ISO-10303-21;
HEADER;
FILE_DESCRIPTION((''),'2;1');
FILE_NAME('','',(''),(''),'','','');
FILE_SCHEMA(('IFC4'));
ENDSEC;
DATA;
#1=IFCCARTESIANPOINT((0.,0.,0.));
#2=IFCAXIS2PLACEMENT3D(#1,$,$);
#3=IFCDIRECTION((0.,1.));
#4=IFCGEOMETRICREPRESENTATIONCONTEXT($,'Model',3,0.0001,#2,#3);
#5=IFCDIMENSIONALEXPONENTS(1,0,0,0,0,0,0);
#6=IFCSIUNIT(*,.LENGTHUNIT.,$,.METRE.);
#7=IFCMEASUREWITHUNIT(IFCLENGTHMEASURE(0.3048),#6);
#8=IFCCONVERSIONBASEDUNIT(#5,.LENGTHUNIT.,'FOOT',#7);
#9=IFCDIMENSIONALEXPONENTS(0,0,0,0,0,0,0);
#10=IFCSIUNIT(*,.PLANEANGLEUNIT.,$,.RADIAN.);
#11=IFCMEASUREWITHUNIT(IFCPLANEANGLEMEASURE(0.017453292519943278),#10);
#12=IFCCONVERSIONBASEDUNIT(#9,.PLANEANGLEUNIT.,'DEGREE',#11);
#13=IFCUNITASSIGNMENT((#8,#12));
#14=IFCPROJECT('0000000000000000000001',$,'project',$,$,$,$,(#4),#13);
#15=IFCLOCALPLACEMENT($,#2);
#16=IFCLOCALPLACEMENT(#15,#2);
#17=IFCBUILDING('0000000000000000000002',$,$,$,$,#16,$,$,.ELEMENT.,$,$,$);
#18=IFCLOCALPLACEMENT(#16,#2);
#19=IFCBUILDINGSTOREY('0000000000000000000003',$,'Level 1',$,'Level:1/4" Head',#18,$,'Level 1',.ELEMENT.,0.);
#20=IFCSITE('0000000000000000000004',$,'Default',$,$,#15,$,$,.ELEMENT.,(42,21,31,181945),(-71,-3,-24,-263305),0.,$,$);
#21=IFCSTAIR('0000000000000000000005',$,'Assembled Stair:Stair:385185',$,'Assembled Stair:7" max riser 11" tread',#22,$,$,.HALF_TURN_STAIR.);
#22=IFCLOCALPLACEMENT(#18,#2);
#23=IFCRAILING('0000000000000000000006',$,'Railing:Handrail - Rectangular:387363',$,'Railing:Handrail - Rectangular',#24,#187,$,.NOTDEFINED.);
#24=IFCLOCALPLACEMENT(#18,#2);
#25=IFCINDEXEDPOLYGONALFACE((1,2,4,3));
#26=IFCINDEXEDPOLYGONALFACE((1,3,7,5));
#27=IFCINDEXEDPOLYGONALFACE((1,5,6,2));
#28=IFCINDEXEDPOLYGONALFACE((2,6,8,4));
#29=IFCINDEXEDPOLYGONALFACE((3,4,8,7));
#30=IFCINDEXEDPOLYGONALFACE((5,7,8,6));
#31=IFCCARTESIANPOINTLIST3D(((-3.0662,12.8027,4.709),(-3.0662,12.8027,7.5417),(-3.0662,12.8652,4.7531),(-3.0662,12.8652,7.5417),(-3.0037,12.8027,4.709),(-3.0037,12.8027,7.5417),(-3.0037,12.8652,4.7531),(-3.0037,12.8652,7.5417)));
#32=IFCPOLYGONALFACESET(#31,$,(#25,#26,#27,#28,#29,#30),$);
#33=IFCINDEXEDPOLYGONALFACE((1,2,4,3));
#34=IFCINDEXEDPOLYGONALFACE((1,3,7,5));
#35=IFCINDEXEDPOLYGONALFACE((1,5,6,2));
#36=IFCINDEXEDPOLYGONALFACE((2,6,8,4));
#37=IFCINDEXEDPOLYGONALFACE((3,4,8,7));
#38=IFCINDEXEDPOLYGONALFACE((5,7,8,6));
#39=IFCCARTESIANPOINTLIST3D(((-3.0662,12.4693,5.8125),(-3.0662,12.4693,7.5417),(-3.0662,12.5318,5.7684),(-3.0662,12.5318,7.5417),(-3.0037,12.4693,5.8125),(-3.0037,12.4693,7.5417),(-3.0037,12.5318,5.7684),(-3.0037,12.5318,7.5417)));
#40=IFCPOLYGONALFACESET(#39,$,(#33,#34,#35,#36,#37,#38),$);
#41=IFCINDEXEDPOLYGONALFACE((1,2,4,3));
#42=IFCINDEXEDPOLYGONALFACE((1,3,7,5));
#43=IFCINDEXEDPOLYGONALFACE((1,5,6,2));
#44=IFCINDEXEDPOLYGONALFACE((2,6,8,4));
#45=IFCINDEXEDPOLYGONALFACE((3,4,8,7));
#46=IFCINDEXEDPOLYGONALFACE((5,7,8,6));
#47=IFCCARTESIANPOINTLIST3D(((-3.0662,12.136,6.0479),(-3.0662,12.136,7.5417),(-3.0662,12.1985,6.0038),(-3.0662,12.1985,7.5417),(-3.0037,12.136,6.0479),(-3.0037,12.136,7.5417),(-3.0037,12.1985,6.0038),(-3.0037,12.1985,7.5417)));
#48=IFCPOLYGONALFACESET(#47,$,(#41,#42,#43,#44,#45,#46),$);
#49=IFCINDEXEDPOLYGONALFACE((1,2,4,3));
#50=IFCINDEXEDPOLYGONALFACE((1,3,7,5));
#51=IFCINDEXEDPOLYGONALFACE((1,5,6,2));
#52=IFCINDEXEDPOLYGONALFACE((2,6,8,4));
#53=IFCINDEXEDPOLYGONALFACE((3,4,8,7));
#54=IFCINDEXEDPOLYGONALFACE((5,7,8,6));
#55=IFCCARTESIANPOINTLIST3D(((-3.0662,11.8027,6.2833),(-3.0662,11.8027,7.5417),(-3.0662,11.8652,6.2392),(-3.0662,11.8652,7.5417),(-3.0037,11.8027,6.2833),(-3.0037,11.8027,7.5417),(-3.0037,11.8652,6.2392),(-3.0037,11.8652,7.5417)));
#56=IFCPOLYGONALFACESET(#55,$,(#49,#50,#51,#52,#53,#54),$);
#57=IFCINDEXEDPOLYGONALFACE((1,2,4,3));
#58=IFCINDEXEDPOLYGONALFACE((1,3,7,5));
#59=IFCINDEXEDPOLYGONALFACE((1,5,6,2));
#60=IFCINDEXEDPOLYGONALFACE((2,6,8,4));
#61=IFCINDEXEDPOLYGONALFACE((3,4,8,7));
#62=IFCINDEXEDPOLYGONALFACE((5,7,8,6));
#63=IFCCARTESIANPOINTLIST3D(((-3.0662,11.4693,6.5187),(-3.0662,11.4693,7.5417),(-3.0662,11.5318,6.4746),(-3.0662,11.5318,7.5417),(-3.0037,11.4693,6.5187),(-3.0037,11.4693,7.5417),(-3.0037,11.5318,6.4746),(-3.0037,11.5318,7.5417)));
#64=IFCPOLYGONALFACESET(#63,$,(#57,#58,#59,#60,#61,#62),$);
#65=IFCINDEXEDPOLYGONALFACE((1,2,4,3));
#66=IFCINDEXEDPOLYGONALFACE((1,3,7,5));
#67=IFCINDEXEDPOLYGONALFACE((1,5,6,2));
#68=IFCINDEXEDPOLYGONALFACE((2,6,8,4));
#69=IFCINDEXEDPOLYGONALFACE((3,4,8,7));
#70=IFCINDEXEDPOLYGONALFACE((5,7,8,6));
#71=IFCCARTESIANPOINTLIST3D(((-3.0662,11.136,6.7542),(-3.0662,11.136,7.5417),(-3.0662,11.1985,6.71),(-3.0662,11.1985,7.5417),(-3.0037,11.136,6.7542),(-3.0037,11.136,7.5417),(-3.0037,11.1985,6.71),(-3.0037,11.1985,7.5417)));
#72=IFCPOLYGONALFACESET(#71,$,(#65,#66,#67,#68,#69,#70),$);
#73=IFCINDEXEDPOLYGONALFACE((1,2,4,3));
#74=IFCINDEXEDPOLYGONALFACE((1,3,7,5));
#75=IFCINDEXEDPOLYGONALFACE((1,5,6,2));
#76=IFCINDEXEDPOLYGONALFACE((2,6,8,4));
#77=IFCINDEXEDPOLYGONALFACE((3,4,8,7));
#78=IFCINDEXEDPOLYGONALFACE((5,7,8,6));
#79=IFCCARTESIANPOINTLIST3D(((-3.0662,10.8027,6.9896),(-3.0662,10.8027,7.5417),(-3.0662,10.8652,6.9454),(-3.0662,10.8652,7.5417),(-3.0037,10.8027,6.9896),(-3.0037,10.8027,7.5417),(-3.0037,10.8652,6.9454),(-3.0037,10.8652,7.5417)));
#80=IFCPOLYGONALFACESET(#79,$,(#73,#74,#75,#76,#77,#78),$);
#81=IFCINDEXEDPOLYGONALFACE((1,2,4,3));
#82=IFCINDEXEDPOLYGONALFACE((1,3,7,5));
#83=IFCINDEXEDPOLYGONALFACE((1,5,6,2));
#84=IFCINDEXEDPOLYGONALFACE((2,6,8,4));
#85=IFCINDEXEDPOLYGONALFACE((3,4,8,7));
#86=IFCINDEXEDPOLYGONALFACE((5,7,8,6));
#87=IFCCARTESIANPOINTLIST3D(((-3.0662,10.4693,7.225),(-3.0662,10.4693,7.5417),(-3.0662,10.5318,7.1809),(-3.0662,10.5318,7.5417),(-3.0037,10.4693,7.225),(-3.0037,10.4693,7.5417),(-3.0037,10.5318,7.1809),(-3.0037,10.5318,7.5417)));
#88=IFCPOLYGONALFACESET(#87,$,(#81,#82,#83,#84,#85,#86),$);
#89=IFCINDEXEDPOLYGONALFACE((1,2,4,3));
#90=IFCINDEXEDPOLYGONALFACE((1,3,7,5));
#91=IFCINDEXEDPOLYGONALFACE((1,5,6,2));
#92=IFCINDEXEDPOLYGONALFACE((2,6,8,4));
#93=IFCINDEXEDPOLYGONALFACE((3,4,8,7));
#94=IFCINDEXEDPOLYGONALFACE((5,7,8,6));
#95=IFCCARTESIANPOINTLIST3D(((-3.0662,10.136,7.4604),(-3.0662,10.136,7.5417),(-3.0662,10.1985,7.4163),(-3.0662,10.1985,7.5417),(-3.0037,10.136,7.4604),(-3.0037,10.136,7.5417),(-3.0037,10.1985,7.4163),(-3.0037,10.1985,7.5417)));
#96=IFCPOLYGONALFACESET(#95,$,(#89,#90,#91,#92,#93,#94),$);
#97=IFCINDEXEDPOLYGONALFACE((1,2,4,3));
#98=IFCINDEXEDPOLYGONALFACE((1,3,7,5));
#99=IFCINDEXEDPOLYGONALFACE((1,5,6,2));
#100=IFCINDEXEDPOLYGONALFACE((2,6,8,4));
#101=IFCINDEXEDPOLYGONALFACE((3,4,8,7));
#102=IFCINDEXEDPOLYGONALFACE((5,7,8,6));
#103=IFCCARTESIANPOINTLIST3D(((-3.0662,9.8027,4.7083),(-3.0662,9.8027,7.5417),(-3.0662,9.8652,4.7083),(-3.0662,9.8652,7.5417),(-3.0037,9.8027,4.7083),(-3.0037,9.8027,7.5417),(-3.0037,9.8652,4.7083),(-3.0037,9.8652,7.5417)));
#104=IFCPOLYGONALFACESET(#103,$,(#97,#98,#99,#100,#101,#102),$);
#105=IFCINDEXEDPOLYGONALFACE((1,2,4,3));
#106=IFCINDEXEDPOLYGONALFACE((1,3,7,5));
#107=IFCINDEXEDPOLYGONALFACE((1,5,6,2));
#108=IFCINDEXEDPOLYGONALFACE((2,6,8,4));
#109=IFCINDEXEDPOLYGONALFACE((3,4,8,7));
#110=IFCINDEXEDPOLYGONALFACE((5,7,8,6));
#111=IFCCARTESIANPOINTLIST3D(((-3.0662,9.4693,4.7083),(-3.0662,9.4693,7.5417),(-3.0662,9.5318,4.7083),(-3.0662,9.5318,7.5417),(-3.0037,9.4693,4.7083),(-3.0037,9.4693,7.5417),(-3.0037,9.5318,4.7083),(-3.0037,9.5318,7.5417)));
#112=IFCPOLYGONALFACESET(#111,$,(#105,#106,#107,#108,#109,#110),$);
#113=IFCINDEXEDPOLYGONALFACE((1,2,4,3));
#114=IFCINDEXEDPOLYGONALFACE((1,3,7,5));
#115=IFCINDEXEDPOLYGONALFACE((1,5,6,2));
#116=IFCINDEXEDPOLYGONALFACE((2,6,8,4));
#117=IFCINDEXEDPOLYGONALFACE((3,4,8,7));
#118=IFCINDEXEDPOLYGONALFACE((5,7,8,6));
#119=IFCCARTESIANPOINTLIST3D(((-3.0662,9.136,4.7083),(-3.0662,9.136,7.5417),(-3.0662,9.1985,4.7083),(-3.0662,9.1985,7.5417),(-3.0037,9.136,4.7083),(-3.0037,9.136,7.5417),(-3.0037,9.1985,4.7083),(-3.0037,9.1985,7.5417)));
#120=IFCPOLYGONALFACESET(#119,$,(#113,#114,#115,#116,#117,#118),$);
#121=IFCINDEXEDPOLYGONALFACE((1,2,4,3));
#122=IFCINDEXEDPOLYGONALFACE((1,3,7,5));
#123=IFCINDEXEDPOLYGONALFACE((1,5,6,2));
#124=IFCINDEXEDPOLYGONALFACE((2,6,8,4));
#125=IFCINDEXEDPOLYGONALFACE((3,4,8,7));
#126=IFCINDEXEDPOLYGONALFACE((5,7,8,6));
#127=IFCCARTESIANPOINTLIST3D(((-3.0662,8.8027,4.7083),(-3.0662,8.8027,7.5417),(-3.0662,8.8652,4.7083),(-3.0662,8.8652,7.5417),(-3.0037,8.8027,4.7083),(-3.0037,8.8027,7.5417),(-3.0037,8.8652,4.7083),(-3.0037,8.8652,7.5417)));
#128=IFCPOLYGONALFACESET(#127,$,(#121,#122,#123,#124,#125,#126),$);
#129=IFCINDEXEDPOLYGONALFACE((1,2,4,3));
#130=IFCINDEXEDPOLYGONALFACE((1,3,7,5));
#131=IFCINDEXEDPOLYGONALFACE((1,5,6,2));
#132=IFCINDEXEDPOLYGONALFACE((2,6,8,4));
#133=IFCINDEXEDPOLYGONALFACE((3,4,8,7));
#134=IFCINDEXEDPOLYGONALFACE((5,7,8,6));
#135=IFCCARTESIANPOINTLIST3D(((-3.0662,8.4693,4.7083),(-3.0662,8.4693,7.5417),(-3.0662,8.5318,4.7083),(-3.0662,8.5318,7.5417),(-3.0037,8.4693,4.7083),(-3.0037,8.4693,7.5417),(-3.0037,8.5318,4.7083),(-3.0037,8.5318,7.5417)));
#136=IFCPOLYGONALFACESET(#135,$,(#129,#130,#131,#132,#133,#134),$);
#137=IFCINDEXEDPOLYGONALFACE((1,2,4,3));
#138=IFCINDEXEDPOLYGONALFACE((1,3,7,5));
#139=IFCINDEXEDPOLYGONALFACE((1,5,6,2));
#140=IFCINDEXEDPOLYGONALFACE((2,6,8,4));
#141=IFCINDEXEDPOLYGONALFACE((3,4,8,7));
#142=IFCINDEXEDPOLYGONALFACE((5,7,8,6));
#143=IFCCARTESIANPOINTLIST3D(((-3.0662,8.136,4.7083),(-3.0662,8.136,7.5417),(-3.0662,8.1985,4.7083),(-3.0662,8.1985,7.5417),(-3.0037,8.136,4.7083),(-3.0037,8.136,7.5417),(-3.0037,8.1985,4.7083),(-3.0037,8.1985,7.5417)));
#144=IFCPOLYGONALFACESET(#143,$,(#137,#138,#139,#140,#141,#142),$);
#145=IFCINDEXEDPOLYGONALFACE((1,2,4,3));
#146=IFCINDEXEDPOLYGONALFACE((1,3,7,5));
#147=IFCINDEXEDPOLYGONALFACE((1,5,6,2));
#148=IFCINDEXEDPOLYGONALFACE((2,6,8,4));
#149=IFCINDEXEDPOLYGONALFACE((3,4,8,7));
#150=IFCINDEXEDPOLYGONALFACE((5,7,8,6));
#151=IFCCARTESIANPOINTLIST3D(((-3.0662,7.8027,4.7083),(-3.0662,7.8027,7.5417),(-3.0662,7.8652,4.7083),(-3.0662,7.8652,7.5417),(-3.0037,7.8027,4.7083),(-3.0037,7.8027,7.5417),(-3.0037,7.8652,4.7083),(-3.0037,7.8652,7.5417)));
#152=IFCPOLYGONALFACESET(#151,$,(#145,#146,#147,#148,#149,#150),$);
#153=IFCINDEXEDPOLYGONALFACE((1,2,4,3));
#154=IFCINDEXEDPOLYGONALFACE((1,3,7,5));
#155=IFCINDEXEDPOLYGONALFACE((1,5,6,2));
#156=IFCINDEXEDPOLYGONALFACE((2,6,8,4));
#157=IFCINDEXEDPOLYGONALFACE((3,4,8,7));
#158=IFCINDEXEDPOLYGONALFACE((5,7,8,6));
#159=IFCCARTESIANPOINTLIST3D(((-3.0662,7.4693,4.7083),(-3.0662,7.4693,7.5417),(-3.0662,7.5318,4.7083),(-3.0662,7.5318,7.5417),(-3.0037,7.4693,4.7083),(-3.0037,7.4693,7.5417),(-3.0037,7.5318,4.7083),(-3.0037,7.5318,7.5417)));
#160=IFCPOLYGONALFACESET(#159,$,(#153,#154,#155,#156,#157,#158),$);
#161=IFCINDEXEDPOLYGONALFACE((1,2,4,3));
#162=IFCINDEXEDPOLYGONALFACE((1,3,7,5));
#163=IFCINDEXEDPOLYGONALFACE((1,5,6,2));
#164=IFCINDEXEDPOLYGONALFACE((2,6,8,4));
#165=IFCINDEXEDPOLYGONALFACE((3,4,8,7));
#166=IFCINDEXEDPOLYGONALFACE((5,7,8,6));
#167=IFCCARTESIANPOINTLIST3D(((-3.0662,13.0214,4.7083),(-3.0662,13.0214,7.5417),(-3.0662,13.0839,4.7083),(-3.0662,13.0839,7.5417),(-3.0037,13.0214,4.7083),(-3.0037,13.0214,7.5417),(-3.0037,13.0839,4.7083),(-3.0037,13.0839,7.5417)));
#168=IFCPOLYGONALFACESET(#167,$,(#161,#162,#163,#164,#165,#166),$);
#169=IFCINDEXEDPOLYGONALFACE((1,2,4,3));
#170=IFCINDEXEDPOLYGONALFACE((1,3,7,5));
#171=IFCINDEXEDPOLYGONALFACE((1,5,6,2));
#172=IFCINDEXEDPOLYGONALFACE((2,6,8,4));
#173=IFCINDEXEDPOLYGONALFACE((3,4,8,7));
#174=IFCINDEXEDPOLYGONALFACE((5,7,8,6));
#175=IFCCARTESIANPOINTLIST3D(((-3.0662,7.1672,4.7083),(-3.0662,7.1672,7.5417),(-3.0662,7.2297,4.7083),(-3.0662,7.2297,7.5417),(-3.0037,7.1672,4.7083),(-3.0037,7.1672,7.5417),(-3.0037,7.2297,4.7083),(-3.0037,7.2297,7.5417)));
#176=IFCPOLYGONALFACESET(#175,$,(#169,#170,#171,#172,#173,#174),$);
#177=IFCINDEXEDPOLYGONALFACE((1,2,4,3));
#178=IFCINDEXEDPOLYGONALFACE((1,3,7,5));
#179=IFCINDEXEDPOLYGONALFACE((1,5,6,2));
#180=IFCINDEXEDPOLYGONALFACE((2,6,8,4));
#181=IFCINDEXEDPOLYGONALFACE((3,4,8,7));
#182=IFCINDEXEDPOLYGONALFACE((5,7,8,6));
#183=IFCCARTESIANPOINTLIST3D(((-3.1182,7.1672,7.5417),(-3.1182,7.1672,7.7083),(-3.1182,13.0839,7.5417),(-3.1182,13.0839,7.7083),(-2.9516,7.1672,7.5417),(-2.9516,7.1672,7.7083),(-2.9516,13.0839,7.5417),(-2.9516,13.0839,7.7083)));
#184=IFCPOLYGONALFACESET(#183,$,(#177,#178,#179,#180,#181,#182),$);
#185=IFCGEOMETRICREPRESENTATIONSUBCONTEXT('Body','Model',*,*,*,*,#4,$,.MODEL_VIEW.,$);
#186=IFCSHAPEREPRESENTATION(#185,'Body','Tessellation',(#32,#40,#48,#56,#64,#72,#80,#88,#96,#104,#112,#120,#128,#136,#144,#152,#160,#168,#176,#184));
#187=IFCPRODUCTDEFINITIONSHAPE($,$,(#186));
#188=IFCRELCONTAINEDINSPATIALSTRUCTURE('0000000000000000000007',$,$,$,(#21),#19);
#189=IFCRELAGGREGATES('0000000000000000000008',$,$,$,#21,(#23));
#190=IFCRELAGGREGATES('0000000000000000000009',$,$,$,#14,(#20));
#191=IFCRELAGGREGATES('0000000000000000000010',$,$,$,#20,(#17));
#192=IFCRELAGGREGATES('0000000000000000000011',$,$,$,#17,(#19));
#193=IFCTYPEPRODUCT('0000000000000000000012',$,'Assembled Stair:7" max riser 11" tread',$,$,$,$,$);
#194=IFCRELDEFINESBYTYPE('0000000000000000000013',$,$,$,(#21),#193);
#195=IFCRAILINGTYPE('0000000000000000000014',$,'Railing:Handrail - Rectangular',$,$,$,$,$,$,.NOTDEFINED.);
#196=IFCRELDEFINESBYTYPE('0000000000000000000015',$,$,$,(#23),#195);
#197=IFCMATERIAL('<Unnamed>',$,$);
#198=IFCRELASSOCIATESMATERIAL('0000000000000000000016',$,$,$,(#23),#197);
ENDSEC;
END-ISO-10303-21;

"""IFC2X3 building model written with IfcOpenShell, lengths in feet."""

from ifc_helpers import new_model, entity, si_unit, converted_unit, direction, frame, frame_2d, origin, origin_2d_with_axis, place, context, subcontext, project, spatial, polyline, rectangle, outline, extrude, material, type_object, element, aggregate, save


model = new_model("IFC2X3")

# Units and contexts
model_context = context("Model", 3, precision=0.0001, world=origin(), true_north=direction((0.0, 1.0)))
body_context = subcontext(model_context, "Body", "Model", "MODEL_VIEW")
ifc_project = project(units=[converted_unit("LENGTHUNIT", "FOOT", entity("IfcLengthMeasure", 0.3048), si_unit("LENGTHUNIT", "METRE"), dimensions=[1, 0, 0, 0, 0, 0, 0]), converted_unit("PLANEANGLEUNIT", "DEGREE", entity("IfcPlaneAngleMeasure", 0.017453292519943278), si_unit("PLANEANGLEUNIT", "RADIAN"), dimensions=[0, 0, 0, 0, 0, 0, 0])], contexts=[model_context])

# Site, building, storey
site_placement = place(None, origin())
site = spatial("IfcSite", under=ifc_project, at=site_placement, Name="Default", CompositionType="ELEMENT", RefLatitude=(42, 21, 31, 181945), RefLongitude=(-71, -3, -24, -263305), RefElevation=0.0)
building_placement = place(site_placement, origin())
building = spatial("IfcBuilding", under=site, at=building_placement, CompositionType="ELEMENT")
storey_placement = place(building_placement, origin())
storey = spatial("IfcBuildingStorey", under=building, at=storey_placement, Name="Level 1", ObjectType="Level:1/4\" Head", LongName="Level 1", CompositionType="ELEMENT", Elevation=0.0)

# Stair
type_product = type_object("IfcTypeProduct", Name="Assembled Stair:7\" max riser 11\" tread")
stair_placement = place(storey_placement, origin())
stair = element("IfcStair", 1, at=stair_placement, inside=storey, type_object=type_product, Name="Assembled Stair:Stair:385185", ObjectType="Assembled Stair:7\" max riser 11\" tread", ShapeType="HALF_TURN_STAIR")
ifc_material_1 = material(Name="<Unnamed>")

# Railing
railing_type = type_object("IfcRailingType", Name="Railing:Handrail - Rectangular", PredefinedType="NOTDEFINED")
railing_1_placement = place(stair_placement, origin())
railing_1 = element("IfcRailing", 2, at=railing_1_placement, type_object=railing_type, material=ifc_material_1, Name="Railing:Handrail - Rectangular:387363", ObjectType="Railing:Handrail - Rectangular", PredefinedType="NOTDEFINED", context=body_context, shape_type="SweptSolid", body=[
    extrude(outline(polyline([(-1.4053, -0.0312), (1.4274, -0.0312), (1.3832, 0.0312), (-1.4053, 0.0312), (-1.4053, -0.0312)])), frame((-3.0662, 12.8339, 6.1364), z_axis=(1.0, 0.0, 0.0), x_axis=(0.0, 0.0, -1.0)), (0.0, 0.0, 1.0), 0.0625),
    extrude(outline(polyline([(-0.8756, -0.0312), (0.8536, -0.0312), (0.8977, 0.0312), (-0.8756, 0.0312), (-0.8756, -0.0312)])), frame((-3.0662, 12.5006, 6.666), z_axis=(1.0, 0.0, 0.0), x_axis=(0.0, 0.0, -1.0)), (0.0, 0.0, 1.0), 0.0625),
    extrude(outline(polyline([(-0.7579, -0.0312), (0.7358, -0.0312), (0.78, 0.0312), (-0.7579, 0.0312), (-0.7579, -0.0312)])), frame((-3.0662, 12.1672, 6.7838), z_axis=(1.0, 0.0, 0.0), x_axis=(0.0, 0.0, -1.0)), (0.0, 0.0, 1.0), 0.0625),
    extrude(outline(polyline([(-0.6402, -0.0312), (0.6181, -0.0312), (0.6623, 0.0312), (-0.6402, 0.0312), (-0.6402, -0.0312)])), frame((-3.0662, 11.8339, 6.9015), z_axis=(1.0, 0.0, 0.0), x_axis=(0.0, 0.0, -1.0)), (0.0, 0.0, 1.0), 0.0625),
    extrude(outline(polyline([(-0.5225, -0.0312), (0.5004, -0.0312), (0.5446, 0.0312), (-0.5225, 0.0312), (-0.5225, -0.0312)])), frame((-3.0662, 11.5006, 7.0192), z_axis=(1.0, 0.0, 0.0), x_axis=(0.0, 0.0, -1.0)), (0.0, 0.0, 1.0), 0.0625),
    extrude(outline(polyline([(-0.4048, -0.0312), (0.3827, -0.0312), (0.4269, 0.0312), (-0.4048, 0.0312), (-0.4048, -0.0312)])), frame((-3.0662, 11.1672, 7.1369), z_axis=(1.0, 0.0, 0.0), x_axis=(0.0, 0.0, -1.0)), (0.0, 0.0, 1.0), 0.0625),
    extrude(outline(polyline([(-0.2871, -0.0312), (0.265, -0.0312), (0.3092, 0.0312), (-0.2871, 0.0312), (-0.2871, -0.0312)])), frame((-3.0662, 10.8339, 7.2546), z_axis=(1.0, 0.0, 0.0), x_axis=(0.0, 0.0, -1.0)), (0.0, 0.0, 1.0), 0.0625),
    extrude(outline(polyline([(-0.1694, -0.0312), (0.1473, -0.0312), (0.1914, 0.0312), (-0.1694, 0.0312), (-0.1694, -0.0312)])), frame((-3.0662, 10.5006, 7.3723), z_axis=(1.0, 0.0, 0.0), x_axis=(0.0, 0.0, -1.0)), (0.0, 0.0, 1.0), 0.0625),
    extrude(outline(polyline([(-0.0517, -0.0312), (0.0296, -0.0312), (0.0737, 0.0312), (-0.0517, 0.0312), (-0.0517, -0.0312)])), frame((-3.0662, 10.1672, 7.49), z_axis=(1.0, 0.0, 0.0), x_axis=(0.0, 0.0, -1.0)), (0.0, 0.0, 1.0), 0.0625),
    extrude(rectangle(XDim=0.0625, YDim=0.0625, at=origin_2d_with_axis()), frame((-3.0349, 9.8339, 4.7083), z_axis=(0.0, 0.0, 1.0), x_axis=(0.0, 1.0, 0.0)), (0.0, 0.0, 1.0), 2.8333),
    extrude(rectangle(XDim=0.0625, YDim=0.0625, at=origin_2d_with_axis()), frame((-3.0349, 9.5006, 4.7083), z_axis=(0.0, 0.0, 1.0), x_axis=(0.0, 1.0, 0.0)), (0.0, 0.0, 1.0), 2.8333),
    extrude(rectangle(XDim=0.0625, YDim=0.0625, at=origin_2d_with_axis()), frame((-3.0349, 9.1672, 4.7083), z_axis=(0.0, 0.0, 1.0), x_axis=(0.0, 1.0, 0.0)), (0.0, 0.0, 1.0), 2.8333),
    extrude(rectangle(XDim=0.0625, YDim=0.0625, at=origin_2d_with_axis()), frame((-3.0349, 8.8339, 4.7083), z_axis=(0.0, 0.0, 1.0), x_axis=(0.0, 1.0, 0.0)), (0.0, 0.0, 1.0), 2.8333),
    extrude(rectangle(XDim=0.0625, YDim=0.0625, at=origin_2d_with_axis()), frame((-3.0349, 8.5006, 4.7083), z_axis=(0.0, 0.0, 1.0), x_axis=(0.0, 1.0, 0.0)), (0.0, 0.0, 1.0), 2.8333),
    extrude(rectangle(XDim=0.0625, YDim=0.0625, at=origin_2d_with_axis()), frame((-3.0349, 8.1672, 4.7083), z_axis=(0.0, 0.0, 1.0), x_axis=(0.0, 1.0, 0.0)), (0.0, 0.0, 1.0), 2.8333),
    extrude(rectangle(XDim=0.0625, YDim=0.0625, at=origin_2d_with_axis()), frame((-3.0349, 7.8339, 4.7083), z_axis=(0.0, 0.0, 1.0), x_axis=(0.0, 1.0, 0.0)), (0.0, 0.0, 1.0), 2.8333),
    extrude(rectangle(XDim=0.0625, YDim=0.0625, at=origin_2d_with_axis()), frame((-3.0349, 7.5006, 4.7083), z_axis=(0.0, 0.0, 1.0), x_axis=(0.0, 1.0, 0.0)), (0.0, 0.0, 1.0), 2.8333),
    extrude(rectangle(XDim=0.0625, YDim=0.0625, at=origin_2d_with_axis()), frame((-3.0349, 13.0527, 4.7083), z_axis=(0.0, 0.0, 1.0), x_axis=(0.0, 1.0, 0.0)), (0.0, 0.0, 1.0), 2.8333),
    extrude(rectangle(XDim=0.0625, YDim=0.0625, at=origin_2d_with_axis()), frame((-3.0349, 7.1985, 4.7083), z_axis=(0.0, 0.0, 1.0), x_axis=(0.0, 1.0, 0.0)), (0.0, 0.0, 1.0), 2.8333),
    extrude(rectangle(XDim=5.9167, YDim=0.1667, at=frame_2d((0.0, 0.0), x_axis=(1.0, 0.0))), frame((-3.0349, 10.1256, 7.5417), z_axis=(0.0, 0.0, 1.0), x_axis=(0.0, 1.0, 0.0)), (0.0, 0.0, 1.0), 0.1667),
])
aggregate(stair, [railing_1])

save(model, "model.ifc")
